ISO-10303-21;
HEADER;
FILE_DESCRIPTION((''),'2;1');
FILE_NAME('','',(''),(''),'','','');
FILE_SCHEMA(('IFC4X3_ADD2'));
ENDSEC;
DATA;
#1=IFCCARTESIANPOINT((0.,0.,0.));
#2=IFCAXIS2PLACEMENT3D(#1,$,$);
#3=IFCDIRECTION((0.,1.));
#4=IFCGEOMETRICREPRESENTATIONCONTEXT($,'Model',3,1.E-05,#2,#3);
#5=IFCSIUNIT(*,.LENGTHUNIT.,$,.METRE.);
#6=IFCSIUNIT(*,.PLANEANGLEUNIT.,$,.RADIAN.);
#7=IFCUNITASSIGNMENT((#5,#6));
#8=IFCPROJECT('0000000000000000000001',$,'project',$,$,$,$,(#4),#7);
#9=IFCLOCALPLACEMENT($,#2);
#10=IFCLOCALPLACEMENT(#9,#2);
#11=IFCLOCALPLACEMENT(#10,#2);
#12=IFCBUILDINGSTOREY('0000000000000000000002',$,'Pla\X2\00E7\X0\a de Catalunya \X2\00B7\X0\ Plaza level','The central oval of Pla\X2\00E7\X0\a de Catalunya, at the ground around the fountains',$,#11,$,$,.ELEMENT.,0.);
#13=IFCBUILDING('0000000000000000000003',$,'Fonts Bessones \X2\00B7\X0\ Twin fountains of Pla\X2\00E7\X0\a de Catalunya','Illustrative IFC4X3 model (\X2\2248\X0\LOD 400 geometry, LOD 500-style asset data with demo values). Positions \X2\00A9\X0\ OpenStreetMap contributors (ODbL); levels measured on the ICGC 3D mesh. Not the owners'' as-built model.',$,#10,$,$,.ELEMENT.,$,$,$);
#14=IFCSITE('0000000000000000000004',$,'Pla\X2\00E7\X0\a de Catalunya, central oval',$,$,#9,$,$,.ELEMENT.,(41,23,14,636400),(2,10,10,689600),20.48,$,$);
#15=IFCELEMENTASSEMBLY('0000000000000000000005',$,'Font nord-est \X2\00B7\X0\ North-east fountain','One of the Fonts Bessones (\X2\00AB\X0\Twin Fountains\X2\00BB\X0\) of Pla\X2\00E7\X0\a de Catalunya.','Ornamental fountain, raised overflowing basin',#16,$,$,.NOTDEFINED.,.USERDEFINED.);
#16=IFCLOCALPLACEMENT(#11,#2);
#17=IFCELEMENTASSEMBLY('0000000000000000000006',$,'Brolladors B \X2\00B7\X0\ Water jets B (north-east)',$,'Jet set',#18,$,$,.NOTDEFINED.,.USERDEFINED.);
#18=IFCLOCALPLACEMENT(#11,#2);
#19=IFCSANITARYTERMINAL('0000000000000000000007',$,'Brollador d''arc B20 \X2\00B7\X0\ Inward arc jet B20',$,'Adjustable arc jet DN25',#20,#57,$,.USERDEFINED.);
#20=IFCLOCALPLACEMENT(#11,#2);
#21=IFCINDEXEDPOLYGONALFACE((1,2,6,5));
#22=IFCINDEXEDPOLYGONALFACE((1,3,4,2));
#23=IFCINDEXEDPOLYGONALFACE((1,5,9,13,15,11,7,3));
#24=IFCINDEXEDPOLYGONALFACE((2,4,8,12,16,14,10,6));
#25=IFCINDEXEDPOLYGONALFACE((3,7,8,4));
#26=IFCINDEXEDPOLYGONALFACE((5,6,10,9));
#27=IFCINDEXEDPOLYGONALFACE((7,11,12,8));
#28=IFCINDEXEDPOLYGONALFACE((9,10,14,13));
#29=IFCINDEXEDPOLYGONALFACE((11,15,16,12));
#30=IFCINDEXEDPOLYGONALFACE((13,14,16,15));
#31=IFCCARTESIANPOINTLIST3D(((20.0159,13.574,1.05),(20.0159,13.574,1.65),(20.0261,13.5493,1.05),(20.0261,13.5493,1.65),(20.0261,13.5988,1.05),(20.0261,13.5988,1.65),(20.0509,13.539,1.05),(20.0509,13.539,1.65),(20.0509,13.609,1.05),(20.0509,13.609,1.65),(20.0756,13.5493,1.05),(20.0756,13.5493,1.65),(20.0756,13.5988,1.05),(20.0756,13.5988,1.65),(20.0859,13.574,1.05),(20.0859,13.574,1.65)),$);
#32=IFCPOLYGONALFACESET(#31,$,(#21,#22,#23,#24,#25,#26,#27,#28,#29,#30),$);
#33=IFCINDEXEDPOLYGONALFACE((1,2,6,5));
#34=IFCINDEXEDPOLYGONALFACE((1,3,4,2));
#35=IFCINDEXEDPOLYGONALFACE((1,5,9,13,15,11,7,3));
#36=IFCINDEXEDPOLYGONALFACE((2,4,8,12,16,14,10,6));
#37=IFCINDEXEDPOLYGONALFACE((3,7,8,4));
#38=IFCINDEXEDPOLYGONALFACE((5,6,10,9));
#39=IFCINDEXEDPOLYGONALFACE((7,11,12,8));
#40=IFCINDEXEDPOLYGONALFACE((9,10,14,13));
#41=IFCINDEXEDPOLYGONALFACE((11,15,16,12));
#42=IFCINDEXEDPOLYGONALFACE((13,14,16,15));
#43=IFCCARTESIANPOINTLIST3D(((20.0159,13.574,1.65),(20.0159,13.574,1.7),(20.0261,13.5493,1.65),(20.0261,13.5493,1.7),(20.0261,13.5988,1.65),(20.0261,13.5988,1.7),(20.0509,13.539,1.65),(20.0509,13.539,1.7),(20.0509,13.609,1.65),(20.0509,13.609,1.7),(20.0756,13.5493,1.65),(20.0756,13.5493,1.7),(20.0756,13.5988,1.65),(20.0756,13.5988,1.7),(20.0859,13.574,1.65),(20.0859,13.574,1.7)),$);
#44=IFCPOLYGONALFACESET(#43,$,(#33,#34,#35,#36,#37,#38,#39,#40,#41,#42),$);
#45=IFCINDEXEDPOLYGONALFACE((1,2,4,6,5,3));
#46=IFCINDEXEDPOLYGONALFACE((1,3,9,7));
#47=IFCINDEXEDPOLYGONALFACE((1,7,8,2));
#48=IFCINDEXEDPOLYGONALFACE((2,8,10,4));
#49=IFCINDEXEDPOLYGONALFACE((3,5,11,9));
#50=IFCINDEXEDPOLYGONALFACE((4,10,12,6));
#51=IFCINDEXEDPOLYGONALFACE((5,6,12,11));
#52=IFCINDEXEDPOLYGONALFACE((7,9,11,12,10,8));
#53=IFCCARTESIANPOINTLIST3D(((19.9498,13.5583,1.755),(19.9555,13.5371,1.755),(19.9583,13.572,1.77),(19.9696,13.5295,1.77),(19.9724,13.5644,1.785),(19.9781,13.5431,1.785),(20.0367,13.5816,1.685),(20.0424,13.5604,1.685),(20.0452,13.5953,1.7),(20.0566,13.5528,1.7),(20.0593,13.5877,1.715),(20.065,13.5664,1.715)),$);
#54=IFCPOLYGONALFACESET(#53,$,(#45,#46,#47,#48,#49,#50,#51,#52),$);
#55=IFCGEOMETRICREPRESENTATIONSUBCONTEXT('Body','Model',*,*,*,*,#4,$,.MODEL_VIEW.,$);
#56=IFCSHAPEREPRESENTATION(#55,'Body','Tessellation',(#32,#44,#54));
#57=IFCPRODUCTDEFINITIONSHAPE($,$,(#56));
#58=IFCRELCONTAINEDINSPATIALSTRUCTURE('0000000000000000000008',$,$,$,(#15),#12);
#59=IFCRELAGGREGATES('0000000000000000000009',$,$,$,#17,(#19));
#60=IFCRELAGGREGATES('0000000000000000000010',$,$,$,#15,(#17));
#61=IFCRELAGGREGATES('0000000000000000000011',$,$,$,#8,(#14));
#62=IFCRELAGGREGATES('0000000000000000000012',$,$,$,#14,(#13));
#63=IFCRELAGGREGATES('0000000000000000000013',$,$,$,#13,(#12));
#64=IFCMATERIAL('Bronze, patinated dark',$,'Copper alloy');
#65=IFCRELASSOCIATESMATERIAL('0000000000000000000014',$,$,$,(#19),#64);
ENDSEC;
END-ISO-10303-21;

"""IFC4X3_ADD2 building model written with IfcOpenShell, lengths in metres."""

from ifc_helpers import new_model, si_unit, direction, frame, origin, place, context, subcontext, project, spatial, polyline, outline, extrude, material, element, aggregate, save


model = new_model("IFC4X3_ADD2")

# Units and contexts
model_context = context("Model", 3, precision=1e-05, world=origin(), true_north=direction((0.0, 1.0)))
body_context = subcontext(model_context, "Body", "Model", "MODEL_VIEW")
ifc_project = project(units=[si_unit("LENGTHUNIT", "METRE"), si_unit("PLANEANGLEUNIT", "RADIAN")], contexts=[model_context])

# Site, building, storey
site_placement = place(None, origin())
site = spatial("IfcSite", under=ifc_project, at=site_placement, Name="Plaça de Catalunya, central oval", CompositionType="ELEMENT", RefLatitude=(41, 23, 14, 636400), RefLongitude=(2, 10, 10, 689600), RefElevation=20.48)
building_placement = place(site_placement, origin())
building = spatial("IfcBuilding", under=site, at=building_placement, Name="Fonts Bessones · Twin fountains of Plaça de Catalunya", Description="Illustrative IFC4X3 model (≈LOD 400 geometry, LOD 500-style asset data with demo values). Positions © OpenStreetMap contributors (ODbL); levels measured on the ICGC 3D mesh. Not the owners' as-built model.", CompositionType="ELEMENT")
storey_placement = place(building_placement, origin())
storey = spatial("IfcBuildingStorey", under=building, at=storey_placement, Name="Plaça de Catalunya · Plaza level", Description="The central oval of Plaça de Catalunya, at the ground around the fountains", CompositionType="ELEMENT", Elevation=0.0)

# Element assemblies, sanitary terminal
assembly_1_placement = place(building_placement, origin())
assembly_1 = element("IfcElementAssembly", 1, at=assembly_1_placement, inside=storey, Name="Font nord-est · North-east fountain", Description="One of the Fonts Bessones («Twin Fountains») of Plaça de Catalunya.", ObjectType="Ornamental fountain, raised overflowing basin", AssemblyPlace="NOTDEFINED", PredefinedType="USERDEFINED")
assembly_2_placement = place(building_placement, origin())
assembly_2 = element("IfcElementAssembly", 2, at=assembly_2_placement, Name="Brolladors B · Water jets B (north-east)", ObjectType="Jet set", AssemblyPlace="NOTDEFINED", PredefinedType="USERDEFINED")
ifc_material_1 = material(Name="Bronze, patinated dark", Category="Copper alloy")
sanitary_terminal_1_placement = place(building_placement, origin())
sanitary_terminal_1 = element("IfcSanitaryTerminal", 3, at=sanitary_terminal_1_placement, material=ifc_material_1, Name="Brollador d'arc B20 · Inward arc jet B20", ObjectType="Adjustable arc jet DN25", PredefinedType="USERDEFINED", context=body_context, shape_type="SweptSolid", body=[
    extrude(outline(polyline([(20.0859, 13.574), (20.0756, 13.5988), (20.0509, 13.609), (20.0261, 13.5988), (20.0159, 13.574), (20.0261, 13.5493), (20.0509, 13.539), (20.0756, 13.5493), (20.0859, 13.574)])), frame((0.0, 0.0, 1.05)), (0.0, 0.0, 1.0), 0.6),
    extrude(outline(polyline([(20.0859, 13.574), (20.0756, 13.5988), (20.0509, 13.609), (20.0261, 13.5988), (20.0159, 13.574), (20.0261, 13.5493), (20.0509, 13.539), (20.0756, 13.5493), (20.0859, 13.574)])), frame((0.0, 0.0, 1.65)), (0.0, 0.0, 1.0), 0.05),
    extrude(outline(polyline([(0.022, 0.0), (0.011, 0.0191), (-0.011, 0.0191), (-0.022, 0.0), (-0.011, -0.0191), (0.011, -0.0191), (0.022, 0.0)])), frame((20.0509, 13.574, 1.7), z_axis=(-0.762456, -0.204299, 0.613941), x_axis=(-0.258819, 0.965926, 0.0)), (0.0, 0.0, 1.0), 0.114),
])
aggregate(assembly_2, [sanitary_terminal_1])
aggregate(assembly_1, [assembly_2])

save(model, "model.ifc")
